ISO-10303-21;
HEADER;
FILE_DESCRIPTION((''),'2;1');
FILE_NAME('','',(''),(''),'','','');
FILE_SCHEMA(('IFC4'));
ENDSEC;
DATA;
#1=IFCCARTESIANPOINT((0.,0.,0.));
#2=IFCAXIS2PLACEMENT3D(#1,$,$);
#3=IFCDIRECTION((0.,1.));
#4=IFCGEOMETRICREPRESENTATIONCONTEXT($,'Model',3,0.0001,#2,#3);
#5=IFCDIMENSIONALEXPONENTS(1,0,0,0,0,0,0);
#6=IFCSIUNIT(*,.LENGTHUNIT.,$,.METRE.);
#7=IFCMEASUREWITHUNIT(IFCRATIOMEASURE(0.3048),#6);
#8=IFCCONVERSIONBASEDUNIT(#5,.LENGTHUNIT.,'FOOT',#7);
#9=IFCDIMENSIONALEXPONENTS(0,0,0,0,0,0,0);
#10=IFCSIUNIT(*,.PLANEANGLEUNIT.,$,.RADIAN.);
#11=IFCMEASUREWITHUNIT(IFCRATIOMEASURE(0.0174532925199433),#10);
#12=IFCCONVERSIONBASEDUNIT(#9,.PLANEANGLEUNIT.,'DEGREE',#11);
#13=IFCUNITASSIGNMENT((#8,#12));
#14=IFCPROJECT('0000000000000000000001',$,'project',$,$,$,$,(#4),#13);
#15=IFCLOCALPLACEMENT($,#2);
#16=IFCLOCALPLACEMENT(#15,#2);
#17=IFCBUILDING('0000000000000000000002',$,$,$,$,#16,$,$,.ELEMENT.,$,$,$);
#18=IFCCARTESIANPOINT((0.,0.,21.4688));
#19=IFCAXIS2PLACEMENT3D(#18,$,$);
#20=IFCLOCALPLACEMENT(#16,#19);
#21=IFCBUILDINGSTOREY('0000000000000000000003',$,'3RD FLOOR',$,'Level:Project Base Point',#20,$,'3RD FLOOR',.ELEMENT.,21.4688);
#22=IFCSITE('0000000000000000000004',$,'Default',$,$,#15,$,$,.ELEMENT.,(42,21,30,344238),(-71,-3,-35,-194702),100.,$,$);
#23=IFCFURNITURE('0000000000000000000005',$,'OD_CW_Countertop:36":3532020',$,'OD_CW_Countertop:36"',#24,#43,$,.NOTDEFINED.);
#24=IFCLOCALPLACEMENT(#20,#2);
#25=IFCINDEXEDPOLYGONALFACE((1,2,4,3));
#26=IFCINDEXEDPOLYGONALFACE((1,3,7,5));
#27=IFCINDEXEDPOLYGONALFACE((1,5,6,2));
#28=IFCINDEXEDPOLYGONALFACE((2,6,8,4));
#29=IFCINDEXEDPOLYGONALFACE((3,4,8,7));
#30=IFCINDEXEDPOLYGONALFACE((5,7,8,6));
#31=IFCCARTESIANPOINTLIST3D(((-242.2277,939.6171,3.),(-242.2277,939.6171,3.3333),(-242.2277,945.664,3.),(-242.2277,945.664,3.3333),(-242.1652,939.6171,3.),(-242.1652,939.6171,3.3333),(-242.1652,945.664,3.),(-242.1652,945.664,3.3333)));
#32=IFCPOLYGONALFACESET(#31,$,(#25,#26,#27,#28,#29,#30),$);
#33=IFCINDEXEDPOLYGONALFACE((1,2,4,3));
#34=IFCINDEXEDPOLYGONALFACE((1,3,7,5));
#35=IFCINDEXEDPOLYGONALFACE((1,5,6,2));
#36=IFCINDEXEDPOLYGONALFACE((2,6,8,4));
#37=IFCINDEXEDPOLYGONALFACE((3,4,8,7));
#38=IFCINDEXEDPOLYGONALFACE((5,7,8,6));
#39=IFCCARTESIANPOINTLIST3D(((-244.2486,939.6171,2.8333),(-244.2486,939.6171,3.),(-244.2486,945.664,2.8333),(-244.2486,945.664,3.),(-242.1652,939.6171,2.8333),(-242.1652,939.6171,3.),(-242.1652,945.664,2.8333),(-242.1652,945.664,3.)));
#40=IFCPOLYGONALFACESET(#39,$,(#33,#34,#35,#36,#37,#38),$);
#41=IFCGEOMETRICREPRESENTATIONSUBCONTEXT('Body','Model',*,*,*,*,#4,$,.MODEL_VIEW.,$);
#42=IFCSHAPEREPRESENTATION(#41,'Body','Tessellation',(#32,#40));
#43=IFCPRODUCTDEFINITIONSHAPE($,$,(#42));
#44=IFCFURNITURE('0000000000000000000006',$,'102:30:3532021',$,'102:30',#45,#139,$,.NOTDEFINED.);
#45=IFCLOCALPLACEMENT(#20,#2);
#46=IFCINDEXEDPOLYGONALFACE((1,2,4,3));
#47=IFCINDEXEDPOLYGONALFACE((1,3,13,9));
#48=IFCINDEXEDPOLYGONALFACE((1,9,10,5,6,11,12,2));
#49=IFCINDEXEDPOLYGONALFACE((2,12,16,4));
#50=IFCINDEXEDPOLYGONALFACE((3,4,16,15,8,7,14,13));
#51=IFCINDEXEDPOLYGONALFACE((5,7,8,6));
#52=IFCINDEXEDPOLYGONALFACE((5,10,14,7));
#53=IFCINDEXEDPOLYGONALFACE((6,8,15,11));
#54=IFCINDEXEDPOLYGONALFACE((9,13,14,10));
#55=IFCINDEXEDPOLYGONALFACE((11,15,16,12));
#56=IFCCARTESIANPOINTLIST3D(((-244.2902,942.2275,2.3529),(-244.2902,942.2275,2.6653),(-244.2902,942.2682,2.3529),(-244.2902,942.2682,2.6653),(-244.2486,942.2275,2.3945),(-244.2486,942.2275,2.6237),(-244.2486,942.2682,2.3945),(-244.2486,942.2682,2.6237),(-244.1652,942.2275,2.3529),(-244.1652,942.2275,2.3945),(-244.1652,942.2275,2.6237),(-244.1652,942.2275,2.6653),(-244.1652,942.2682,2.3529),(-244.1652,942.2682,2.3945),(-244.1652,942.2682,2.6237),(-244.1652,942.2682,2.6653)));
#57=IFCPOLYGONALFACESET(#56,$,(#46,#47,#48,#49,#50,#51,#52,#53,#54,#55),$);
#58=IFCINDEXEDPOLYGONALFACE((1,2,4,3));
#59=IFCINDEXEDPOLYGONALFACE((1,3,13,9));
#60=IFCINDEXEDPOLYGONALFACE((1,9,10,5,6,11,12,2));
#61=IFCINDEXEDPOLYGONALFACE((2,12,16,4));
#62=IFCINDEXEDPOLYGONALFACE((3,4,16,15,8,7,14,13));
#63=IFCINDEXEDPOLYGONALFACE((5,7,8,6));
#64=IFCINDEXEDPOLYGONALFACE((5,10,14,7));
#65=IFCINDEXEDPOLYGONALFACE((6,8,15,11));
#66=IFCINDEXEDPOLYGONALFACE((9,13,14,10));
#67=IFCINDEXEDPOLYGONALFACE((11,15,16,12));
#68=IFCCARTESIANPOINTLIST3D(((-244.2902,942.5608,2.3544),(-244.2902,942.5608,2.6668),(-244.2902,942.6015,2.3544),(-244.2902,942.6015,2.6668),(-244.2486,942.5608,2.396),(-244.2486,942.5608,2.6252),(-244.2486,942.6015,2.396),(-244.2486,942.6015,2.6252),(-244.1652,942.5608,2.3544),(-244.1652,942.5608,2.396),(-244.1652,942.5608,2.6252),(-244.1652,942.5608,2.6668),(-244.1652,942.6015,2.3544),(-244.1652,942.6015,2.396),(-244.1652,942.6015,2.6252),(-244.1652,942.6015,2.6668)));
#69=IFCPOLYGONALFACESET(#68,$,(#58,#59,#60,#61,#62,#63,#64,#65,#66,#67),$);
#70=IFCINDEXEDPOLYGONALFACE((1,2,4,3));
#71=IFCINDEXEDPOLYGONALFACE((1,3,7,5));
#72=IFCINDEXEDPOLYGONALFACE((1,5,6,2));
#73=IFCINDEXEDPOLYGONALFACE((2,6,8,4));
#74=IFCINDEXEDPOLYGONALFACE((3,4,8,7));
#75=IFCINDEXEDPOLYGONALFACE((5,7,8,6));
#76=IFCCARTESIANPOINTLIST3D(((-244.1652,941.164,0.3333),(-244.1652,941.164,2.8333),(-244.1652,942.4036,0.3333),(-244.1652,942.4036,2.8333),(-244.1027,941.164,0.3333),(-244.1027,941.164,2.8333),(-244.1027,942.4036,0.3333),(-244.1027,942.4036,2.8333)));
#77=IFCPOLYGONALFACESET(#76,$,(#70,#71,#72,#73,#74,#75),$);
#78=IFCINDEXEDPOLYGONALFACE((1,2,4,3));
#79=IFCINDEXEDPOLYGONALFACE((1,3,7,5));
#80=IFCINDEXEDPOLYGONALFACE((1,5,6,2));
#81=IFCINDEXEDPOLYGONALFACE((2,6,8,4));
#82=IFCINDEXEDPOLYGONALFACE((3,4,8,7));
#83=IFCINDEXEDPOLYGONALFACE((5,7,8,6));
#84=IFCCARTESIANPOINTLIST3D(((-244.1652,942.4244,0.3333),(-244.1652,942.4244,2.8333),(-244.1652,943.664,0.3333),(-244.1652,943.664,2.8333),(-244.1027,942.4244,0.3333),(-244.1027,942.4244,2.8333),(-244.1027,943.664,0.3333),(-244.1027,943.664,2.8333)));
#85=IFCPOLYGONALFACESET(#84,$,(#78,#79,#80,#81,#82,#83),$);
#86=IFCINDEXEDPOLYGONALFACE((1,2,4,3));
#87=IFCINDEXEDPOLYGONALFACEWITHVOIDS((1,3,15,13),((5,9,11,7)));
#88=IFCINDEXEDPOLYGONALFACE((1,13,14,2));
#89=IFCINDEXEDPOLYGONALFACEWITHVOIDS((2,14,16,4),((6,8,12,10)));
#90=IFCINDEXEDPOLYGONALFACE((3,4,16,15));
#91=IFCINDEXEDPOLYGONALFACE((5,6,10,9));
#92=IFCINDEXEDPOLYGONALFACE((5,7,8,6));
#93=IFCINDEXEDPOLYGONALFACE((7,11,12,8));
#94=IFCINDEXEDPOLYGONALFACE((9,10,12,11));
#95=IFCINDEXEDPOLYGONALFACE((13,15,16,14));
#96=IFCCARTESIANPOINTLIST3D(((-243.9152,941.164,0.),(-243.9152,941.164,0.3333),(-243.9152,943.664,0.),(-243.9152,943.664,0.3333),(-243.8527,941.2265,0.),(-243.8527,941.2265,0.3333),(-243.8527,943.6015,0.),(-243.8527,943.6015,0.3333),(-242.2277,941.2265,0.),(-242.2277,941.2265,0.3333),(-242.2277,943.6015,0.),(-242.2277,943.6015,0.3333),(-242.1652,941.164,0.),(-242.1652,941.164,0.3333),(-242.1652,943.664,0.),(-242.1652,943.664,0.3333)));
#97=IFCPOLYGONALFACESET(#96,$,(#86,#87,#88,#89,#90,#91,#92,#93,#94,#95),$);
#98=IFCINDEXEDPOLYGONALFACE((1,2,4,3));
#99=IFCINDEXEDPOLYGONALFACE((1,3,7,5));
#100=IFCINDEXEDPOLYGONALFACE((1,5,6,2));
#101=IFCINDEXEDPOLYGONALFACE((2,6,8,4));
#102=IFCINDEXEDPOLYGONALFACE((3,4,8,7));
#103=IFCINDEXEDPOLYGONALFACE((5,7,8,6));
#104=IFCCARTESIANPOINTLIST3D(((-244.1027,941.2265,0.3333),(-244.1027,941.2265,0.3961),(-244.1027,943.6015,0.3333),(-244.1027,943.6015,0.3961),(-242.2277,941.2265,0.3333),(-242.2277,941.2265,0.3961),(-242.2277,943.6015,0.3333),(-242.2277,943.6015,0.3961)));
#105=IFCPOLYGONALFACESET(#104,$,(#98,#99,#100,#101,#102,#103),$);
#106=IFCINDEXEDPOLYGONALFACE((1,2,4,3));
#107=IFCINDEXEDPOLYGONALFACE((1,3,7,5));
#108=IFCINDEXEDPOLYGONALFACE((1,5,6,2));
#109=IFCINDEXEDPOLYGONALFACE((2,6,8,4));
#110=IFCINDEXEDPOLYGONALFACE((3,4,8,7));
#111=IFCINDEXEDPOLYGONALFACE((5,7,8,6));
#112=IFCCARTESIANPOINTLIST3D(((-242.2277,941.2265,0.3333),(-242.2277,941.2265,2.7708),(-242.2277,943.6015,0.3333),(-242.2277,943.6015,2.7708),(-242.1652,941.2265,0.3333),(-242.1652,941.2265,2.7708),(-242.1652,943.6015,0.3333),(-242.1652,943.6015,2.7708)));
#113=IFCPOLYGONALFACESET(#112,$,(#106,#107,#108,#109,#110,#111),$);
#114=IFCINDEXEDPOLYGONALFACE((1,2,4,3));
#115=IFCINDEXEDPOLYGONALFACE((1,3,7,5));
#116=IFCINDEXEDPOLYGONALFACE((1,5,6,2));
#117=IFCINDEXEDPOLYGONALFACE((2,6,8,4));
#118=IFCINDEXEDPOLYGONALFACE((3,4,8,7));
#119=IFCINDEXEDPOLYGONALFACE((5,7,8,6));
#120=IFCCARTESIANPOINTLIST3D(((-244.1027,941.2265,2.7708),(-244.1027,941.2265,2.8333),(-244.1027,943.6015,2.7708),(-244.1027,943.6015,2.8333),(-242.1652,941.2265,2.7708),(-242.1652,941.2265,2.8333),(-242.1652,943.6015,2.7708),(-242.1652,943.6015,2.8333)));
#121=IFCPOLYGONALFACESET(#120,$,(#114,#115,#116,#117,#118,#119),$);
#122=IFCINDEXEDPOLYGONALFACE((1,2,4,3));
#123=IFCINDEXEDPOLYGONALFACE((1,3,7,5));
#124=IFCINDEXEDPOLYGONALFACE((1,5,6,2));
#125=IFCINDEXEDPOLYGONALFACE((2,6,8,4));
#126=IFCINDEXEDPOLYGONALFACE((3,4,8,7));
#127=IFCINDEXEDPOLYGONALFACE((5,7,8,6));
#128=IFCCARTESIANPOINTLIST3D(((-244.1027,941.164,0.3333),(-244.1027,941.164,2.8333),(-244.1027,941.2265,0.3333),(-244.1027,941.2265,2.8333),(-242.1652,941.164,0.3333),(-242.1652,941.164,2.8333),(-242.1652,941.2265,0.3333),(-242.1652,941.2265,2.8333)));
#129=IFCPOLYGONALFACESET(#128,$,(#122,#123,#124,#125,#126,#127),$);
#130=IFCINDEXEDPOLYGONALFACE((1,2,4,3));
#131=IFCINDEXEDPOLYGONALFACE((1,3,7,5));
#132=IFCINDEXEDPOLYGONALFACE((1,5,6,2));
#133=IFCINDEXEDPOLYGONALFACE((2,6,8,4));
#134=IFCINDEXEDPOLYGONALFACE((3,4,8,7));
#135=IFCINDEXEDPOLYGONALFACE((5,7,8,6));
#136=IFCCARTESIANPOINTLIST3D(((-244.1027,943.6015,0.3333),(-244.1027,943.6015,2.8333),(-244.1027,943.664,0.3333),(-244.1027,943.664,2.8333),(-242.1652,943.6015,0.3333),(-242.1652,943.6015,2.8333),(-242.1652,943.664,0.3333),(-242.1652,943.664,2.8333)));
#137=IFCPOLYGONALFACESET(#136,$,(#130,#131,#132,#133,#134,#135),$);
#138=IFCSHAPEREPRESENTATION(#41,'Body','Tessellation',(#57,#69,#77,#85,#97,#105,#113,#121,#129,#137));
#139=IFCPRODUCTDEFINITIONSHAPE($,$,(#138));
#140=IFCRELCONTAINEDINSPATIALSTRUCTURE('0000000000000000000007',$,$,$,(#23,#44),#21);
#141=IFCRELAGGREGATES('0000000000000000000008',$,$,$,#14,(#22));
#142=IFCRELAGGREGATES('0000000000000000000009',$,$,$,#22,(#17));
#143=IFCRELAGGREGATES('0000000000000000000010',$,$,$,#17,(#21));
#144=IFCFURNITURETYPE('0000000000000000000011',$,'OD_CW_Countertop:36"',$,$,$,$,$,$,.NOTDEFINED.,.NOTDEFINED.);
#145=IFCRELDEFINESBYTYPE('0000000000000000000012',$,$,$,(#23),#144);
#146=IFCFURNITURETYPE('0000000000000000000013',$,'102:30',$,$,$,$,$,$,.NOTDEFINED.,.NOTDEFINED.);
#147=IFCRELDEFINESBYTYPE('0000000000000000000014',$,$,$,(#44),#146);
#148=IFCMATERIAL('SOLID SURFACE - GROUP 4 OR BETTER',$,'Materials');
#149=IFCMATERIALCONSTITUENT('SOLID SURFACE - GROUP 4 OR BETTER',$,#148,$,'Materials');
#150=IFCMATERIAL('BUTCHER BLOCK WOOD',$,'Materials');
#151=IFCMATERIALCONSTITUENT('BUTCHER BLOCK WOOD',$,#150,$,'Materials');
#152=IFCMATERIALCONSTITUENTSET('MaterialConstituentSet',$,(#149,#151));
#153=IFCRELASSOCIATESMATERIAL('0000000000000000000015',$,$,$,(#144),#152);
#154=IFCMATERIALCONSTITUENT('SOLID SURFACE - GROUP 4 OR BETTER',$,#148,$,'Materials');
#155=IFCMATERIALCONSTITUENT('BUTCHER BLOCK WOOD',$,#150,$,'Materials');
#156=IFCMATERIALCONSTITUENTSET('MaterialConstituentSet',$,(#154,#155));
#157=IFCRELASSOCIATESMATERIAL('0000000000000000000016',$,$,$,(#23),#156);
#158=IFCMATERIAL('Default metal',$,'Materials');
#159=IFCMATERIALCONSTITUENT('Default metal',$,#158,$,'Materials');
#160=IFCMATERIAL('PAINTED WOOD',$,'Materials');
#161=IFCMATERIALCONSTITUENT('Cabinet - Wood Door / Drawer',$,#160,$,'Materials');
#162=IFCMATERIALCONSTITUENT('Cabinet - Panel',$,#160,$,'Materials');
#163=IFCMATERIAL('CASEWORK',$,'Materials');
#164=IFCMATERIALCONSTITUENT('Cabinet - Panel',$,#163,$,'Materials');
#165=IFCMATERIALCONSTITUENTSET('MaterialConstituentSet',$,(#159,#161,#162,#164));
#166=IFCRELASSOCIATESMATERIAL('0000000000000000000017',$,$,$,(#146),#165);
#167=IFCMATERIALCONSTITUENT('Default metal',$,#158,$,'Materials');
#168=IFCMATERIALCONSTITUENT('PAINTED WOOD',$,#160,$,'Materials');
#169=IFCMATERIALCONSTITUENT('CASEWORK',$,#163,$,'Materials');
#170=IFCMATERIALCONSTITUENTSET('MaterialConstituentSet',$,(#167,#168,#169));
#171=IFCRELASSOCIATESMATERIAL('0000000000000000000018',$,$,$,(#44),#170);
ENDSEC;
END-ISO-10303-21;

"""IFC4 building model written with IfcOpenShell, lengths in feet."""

from ifc_helpers import new_model, entity, si_unit, converted_unit, direction, frame, frame_2d, origin, origin_2d_with_axis, place, context, subcontext, project, spatial, polyline, rectangle, outline, extrude, source, transform, mapped, material, constituent, constituent_set, type_object, type_shapes, element, save


model = new_model("IFC4")

# Units and contexts
model_context = context("Model", 3, precision=0.0001, world=origin(), true_north=direction((0.0, 1.0)))
body_context = subcontext(model_context, "Body", "Model", "MODEL_VIEW")
ifc_project = project(units=[converted_unit("LENGTHUNIT", "FOOT", entity("IfcRatioMeasure", 0.3048), si_unit("LENGTHUNIT", "METRE"), dimensions=[1, 0, 0, 0, 0, 0, 0]), converted_unit("PLANEANGLEUNIT", "DEGREE", entity("IfcRatioMeasure", 0.0174532925199433), si_unit("PLANEANGLEUNIT", "RADIAN"), dimensions=[0, 0, 0, 0, 0, 0, 0])], contexts=[model_context])

# Site, building, storey
site_placement = place(None, origin())
site = spatial("IfcSite", under=ifc_project, at=site_placement, Name="Default", CompositionType="ELEMENT", RefLatitude=(42, 21, 30, 344238), RefLongitude=(-71, -3, -35, -194702), RefElevation=100.0)
building_placement = place(site_placement, origin())
building = spatial("IfcBuilding", under=site, at=building_placement, CompositionType="ELEMENT")
storey_placement = place(building_placement, frame((0.0, 0.0, 21.4688)))
storey = spatial("IfcBuildingStorey", under=building, at=storey_placement, Name="3RD FLOOR", ObjectType="Level:Project Base Point", LongName="3RD FLOOR", CompositionType="ELEMENT", Elevation=21.4688)

# Furniture
ifc_material_1 = material(Name="CASEWORK", Category="Materials")
ifc_material_2 = material(Name="PAINTED WOOD", Category="Materials")
ifc_material_3 = material(Name="SOLID SURFACE - GROUP 4 OR BETTER", Category="Materials")
ifc_constituent_1 = constituent(ifc_material_3, Name="SOLID SURFACE - GROUP 4 OR BETTER", Category="Materials")
ifc_material_4 = material(Name="BUTCHER BLOCK WOOD", Category="Materials")
ifc_constituent_2 = constituent(ifc_material_4, Name="BUTCHER BLOCK WOOD", Category="Materials")
ifc_constituent_set_1 = constituent_set(constituents=[ifc_constituent_1, ifc_constituent_2], Name="MaterialConstituentSet")
ifc_constituent_3 = constituent(ifc_material_3, Name="SOLID SURFACE - GROUP 4 OR BETTER", Category="Materials")
ifc_constituent_4 = constituent(ifc_material_4, Name="BUTCHER BLOCK WOOD", Category="Materials")
ifc_constituent_set_2 = constituent_set(constituents=[ifc_constituent_3, ifc_constituent_4], Name="MaterialConstituentSet")
furniture_type_1 = type_object("IfcFurnitureType", Name="OD_CW_Countertop:36\"", AssemblyPlace="NOTDEFINED", PredefinedType="NOTDEFINED", material=ifc_constituent_set_2)
shared_shape_1 = source(origin(), body_context, "Body", "SweptSolid", [
    extrude(rectangle(XDim=6.0469, YDim=0.0625, at=frame_2d((0.0, 0.0), x_axis=(1.0, 0.0))), frame((3.0234, 0.0313, 0.1667)), (0.0, 0.0, 1.0), 0.3333),
    extrude(rectangle(XDim=6.0469, YDim=2.0833, at=origin_2d_with_axis()), frame((3.0234, 1.0417, 0.0)), (0.0, 0.0, 1.0), 0.1667),
])
type_shapes(furniture_type_1, [shared_shape_1])
furniture_1_placement = place(storey_placement, frame((-242.1652, 939.6171, 2.8333), z_axis=(0.0, 0.0, 1.0), x_axis=(0.0, 1.0, 0.0)))
element("IfcFurniture", 1, at=furniture_1_placement, inside=storey, type_object=furniture_type_1, material=ifc_constituent_set_1, Name="OD_CW_Countertop:36\":3532020", ObjectType="OD_CW_Countertop:36\"", PredefinedType="NOTDEFINED", context=body_context, shape_type="MappedRepresentation", body=[
    mapped(shared_shape_1, transform((0.0, 0.0, 0.0), scale=1.0)),
])
ifc_material_5 = material(Name="Default metal", Category="Materials")
ifc_constituent_5 = constituent(ifc_material_5, Name="Default metal", Category="Materials")
ifc_constituent_6 = constituent(ifc_material_2, Name="PAINTED WOOD", Category="Materials")
ifc_constituent_7 = constituent(ifc_material_1, Name="CASEWORK", Category="Materials")
ifc_constituent_set_3 = constituent_set(constituents=[ifc_constituent_5, ifc_constituent_6, ifc_constituent_7], Name="MaterialConstituentSet")
ifc_constituent_8 = constituent(ifc_material_5, Name="Default metal", Category="Materials")
ifc_constituent_9 = constituent(ifc_material_2, Name="Cabinet - Wood Door / Drawer", Category="Materials")
ifc_constituent_10 = constituent(ifc_material_2, Name="Cabinet - Panel", Category="Materials")
ifc_constituent_11 = constituent(ifc_material_1, Name="Cabinet - Panel", Category="Materials")
ifc_constituent_set_4 = constituent_set(constituents=[ifc_constituent_8, ifc_constituent_9, ifc_constituent_10, ifc_constituent_11], Name="MaterialConstituentSet")
furniture_type_2 = type_object("IfcFurnitureType", Name="102:30", AssemblyPlace="NOTDEFINED", PredefinedType="NOTDEFINED", material=ifc_constituent_set_4)
shared_shape_2 = source(origin(), body_context, "Body", "SweptSolid", [
    extrude(outline(polyline([(0.1146, -0.0521), (0.1562, -0.0521), (0.1562, 0.0729), (-0.1562, 0.0729), (-0.1562, -0.0521), (-0.1146, -0.0521), (-0.1146, 0.0313), (0.1146, 0.0313), (0.1146, -0.0521)])), frame((0.2073, -2.0521, 2.5091), z_axis=(1.0, 0.0, 0.0), x_axis=(0.0, 0.0, 1.0)), (0.0, 0.0, 1.0), 0.0407),
    extrude(outline(polyline([(0.1146, -0.0521), (0.1562, -0.0521), (0.1562, 0.0729), (-0.1562, 0.0729), (-0.1562, -0.0521), (-0.1146, -0.0521), (-0.1146, 0.0313), (0.1146, 0.0313), (0.1146, -0.0521)])), frame((-0.126, -2.0521, 2.5106), z_axis=(1.0, 0.0, 0.0), x_axis=(0.0, 0.0, 1.0)), (0.0, 0.0, 1.0), 0.0407),
    extrude(rectangle(XDim=0.0625, YDim=1.2396, at=frame_2d((0.0, 0.0), x_axis=(1.0, 0.0))), frame((0.6917, -1.9688, 0.3333), z_axis=(0.0, 0.0, 1.0), x_axis=(0.0, 1.0, 0.0)), (0.0, 0.0, 1.0), 2.5),
    extrude(rectangle(XDim=0.0625, YDim=1.2396, at=origin_2d_with_axis()), frame((-0.5687, -1.9688, 0.3333), z_axis=(0.0, 0.0, 1.0), x_axis=(0.0, 1.0, 0.0)), (0.0, 0.0, 1.0), 2.5),
    extrude(outline(polyline([(-1.25, -0.875), (1.25, -0.875), (1.25, 0.875), (-1.25, 0.875), (-1.25, -0.875)]), holes=[polyline([(-1.1875, -0.8125), (-1.1875, 0.8125), (1.1875, 0.8125), (1.1875, -0.8125), (-1.1875, -0.8125)])]), frame((0.0615, -0.875, 0.0)), (0.0, 0.0, 1.0), 0.3333),
    extrude(rectangle(XDim=2.375, YDim=1.875, at=frame_2d((0.0, 0.0), x_axis=(1.0, 0.0))), frame((0.0615, -1.0, 0.3333), z_axis=(0.0, 0.0, 1.0), x_axis=(-1.0, 0.0, 0.0)), (0.0, 0.0, 1.0), 0.0627),
    extrude(rectangle(XDim=0.0625, YDim=2.375, at=origin_2d_with_axis()), frame((0.0615, -0.0312, 0.3333), z_axis=(0.0, 0.0, 1.0), x_axis=(0.0, 1.0, 0.0)), (0.0, 0.0, 1.0), 2.4375),
    extrude(rectangle(XDim=2.375, YDim=1.9375, at=origin_2d_with_axis()), frame((0.0615, -0.9688, 2.7708), z_axis=(0.0, 0.0, 1.0), x_axis=(-1.0, 0.0, 0.0)), (0.0, 0.0, 1.0), 0.0625),
    extrude(rectangle(XDim=0.0625, YDim=1.9375, at=frame_2d((0.0, 0.0), x_axis=(1.0, 0.0))), frame((1.2802, -0.9687, 0.3333)), (0.0, 0.0, 1.0), 2.5),
    extrude(rectangle(XDim=0.0625, YDim=1.9375, at=frame_2d((0.0, 0.0), x_axis=(1.0, 0.0))), frame((-1.1573, -0.9687, 0.3333)), (0.0, 0.0, 1.0), 2.5),
])
type_shapes(furniture_type_2, [shared_shape_2])
furniture_2_placement = place(storey_placement, frame((-242.1652, 942.4755, 0.0), z_axis=(0.0, 0.0, 1.0), x_axis=(0.0, -1.0, 0.0)))
element("IfcFurniture", 2, at=furniture_2_placement, inside=storey, type_object=furniture_type_2, material=ifc_constituent_set_3, Name="102:30:3532021", ObjectType="102:30", PredefinedType="NOTDEFINED", context=body_context, shape_type="MappedRepresentation", body=[
    mapped(shared_shape_2, transform((0.0, 0.0, 0.0), scale=1.0)),
])

save(model, "model.ifc")
